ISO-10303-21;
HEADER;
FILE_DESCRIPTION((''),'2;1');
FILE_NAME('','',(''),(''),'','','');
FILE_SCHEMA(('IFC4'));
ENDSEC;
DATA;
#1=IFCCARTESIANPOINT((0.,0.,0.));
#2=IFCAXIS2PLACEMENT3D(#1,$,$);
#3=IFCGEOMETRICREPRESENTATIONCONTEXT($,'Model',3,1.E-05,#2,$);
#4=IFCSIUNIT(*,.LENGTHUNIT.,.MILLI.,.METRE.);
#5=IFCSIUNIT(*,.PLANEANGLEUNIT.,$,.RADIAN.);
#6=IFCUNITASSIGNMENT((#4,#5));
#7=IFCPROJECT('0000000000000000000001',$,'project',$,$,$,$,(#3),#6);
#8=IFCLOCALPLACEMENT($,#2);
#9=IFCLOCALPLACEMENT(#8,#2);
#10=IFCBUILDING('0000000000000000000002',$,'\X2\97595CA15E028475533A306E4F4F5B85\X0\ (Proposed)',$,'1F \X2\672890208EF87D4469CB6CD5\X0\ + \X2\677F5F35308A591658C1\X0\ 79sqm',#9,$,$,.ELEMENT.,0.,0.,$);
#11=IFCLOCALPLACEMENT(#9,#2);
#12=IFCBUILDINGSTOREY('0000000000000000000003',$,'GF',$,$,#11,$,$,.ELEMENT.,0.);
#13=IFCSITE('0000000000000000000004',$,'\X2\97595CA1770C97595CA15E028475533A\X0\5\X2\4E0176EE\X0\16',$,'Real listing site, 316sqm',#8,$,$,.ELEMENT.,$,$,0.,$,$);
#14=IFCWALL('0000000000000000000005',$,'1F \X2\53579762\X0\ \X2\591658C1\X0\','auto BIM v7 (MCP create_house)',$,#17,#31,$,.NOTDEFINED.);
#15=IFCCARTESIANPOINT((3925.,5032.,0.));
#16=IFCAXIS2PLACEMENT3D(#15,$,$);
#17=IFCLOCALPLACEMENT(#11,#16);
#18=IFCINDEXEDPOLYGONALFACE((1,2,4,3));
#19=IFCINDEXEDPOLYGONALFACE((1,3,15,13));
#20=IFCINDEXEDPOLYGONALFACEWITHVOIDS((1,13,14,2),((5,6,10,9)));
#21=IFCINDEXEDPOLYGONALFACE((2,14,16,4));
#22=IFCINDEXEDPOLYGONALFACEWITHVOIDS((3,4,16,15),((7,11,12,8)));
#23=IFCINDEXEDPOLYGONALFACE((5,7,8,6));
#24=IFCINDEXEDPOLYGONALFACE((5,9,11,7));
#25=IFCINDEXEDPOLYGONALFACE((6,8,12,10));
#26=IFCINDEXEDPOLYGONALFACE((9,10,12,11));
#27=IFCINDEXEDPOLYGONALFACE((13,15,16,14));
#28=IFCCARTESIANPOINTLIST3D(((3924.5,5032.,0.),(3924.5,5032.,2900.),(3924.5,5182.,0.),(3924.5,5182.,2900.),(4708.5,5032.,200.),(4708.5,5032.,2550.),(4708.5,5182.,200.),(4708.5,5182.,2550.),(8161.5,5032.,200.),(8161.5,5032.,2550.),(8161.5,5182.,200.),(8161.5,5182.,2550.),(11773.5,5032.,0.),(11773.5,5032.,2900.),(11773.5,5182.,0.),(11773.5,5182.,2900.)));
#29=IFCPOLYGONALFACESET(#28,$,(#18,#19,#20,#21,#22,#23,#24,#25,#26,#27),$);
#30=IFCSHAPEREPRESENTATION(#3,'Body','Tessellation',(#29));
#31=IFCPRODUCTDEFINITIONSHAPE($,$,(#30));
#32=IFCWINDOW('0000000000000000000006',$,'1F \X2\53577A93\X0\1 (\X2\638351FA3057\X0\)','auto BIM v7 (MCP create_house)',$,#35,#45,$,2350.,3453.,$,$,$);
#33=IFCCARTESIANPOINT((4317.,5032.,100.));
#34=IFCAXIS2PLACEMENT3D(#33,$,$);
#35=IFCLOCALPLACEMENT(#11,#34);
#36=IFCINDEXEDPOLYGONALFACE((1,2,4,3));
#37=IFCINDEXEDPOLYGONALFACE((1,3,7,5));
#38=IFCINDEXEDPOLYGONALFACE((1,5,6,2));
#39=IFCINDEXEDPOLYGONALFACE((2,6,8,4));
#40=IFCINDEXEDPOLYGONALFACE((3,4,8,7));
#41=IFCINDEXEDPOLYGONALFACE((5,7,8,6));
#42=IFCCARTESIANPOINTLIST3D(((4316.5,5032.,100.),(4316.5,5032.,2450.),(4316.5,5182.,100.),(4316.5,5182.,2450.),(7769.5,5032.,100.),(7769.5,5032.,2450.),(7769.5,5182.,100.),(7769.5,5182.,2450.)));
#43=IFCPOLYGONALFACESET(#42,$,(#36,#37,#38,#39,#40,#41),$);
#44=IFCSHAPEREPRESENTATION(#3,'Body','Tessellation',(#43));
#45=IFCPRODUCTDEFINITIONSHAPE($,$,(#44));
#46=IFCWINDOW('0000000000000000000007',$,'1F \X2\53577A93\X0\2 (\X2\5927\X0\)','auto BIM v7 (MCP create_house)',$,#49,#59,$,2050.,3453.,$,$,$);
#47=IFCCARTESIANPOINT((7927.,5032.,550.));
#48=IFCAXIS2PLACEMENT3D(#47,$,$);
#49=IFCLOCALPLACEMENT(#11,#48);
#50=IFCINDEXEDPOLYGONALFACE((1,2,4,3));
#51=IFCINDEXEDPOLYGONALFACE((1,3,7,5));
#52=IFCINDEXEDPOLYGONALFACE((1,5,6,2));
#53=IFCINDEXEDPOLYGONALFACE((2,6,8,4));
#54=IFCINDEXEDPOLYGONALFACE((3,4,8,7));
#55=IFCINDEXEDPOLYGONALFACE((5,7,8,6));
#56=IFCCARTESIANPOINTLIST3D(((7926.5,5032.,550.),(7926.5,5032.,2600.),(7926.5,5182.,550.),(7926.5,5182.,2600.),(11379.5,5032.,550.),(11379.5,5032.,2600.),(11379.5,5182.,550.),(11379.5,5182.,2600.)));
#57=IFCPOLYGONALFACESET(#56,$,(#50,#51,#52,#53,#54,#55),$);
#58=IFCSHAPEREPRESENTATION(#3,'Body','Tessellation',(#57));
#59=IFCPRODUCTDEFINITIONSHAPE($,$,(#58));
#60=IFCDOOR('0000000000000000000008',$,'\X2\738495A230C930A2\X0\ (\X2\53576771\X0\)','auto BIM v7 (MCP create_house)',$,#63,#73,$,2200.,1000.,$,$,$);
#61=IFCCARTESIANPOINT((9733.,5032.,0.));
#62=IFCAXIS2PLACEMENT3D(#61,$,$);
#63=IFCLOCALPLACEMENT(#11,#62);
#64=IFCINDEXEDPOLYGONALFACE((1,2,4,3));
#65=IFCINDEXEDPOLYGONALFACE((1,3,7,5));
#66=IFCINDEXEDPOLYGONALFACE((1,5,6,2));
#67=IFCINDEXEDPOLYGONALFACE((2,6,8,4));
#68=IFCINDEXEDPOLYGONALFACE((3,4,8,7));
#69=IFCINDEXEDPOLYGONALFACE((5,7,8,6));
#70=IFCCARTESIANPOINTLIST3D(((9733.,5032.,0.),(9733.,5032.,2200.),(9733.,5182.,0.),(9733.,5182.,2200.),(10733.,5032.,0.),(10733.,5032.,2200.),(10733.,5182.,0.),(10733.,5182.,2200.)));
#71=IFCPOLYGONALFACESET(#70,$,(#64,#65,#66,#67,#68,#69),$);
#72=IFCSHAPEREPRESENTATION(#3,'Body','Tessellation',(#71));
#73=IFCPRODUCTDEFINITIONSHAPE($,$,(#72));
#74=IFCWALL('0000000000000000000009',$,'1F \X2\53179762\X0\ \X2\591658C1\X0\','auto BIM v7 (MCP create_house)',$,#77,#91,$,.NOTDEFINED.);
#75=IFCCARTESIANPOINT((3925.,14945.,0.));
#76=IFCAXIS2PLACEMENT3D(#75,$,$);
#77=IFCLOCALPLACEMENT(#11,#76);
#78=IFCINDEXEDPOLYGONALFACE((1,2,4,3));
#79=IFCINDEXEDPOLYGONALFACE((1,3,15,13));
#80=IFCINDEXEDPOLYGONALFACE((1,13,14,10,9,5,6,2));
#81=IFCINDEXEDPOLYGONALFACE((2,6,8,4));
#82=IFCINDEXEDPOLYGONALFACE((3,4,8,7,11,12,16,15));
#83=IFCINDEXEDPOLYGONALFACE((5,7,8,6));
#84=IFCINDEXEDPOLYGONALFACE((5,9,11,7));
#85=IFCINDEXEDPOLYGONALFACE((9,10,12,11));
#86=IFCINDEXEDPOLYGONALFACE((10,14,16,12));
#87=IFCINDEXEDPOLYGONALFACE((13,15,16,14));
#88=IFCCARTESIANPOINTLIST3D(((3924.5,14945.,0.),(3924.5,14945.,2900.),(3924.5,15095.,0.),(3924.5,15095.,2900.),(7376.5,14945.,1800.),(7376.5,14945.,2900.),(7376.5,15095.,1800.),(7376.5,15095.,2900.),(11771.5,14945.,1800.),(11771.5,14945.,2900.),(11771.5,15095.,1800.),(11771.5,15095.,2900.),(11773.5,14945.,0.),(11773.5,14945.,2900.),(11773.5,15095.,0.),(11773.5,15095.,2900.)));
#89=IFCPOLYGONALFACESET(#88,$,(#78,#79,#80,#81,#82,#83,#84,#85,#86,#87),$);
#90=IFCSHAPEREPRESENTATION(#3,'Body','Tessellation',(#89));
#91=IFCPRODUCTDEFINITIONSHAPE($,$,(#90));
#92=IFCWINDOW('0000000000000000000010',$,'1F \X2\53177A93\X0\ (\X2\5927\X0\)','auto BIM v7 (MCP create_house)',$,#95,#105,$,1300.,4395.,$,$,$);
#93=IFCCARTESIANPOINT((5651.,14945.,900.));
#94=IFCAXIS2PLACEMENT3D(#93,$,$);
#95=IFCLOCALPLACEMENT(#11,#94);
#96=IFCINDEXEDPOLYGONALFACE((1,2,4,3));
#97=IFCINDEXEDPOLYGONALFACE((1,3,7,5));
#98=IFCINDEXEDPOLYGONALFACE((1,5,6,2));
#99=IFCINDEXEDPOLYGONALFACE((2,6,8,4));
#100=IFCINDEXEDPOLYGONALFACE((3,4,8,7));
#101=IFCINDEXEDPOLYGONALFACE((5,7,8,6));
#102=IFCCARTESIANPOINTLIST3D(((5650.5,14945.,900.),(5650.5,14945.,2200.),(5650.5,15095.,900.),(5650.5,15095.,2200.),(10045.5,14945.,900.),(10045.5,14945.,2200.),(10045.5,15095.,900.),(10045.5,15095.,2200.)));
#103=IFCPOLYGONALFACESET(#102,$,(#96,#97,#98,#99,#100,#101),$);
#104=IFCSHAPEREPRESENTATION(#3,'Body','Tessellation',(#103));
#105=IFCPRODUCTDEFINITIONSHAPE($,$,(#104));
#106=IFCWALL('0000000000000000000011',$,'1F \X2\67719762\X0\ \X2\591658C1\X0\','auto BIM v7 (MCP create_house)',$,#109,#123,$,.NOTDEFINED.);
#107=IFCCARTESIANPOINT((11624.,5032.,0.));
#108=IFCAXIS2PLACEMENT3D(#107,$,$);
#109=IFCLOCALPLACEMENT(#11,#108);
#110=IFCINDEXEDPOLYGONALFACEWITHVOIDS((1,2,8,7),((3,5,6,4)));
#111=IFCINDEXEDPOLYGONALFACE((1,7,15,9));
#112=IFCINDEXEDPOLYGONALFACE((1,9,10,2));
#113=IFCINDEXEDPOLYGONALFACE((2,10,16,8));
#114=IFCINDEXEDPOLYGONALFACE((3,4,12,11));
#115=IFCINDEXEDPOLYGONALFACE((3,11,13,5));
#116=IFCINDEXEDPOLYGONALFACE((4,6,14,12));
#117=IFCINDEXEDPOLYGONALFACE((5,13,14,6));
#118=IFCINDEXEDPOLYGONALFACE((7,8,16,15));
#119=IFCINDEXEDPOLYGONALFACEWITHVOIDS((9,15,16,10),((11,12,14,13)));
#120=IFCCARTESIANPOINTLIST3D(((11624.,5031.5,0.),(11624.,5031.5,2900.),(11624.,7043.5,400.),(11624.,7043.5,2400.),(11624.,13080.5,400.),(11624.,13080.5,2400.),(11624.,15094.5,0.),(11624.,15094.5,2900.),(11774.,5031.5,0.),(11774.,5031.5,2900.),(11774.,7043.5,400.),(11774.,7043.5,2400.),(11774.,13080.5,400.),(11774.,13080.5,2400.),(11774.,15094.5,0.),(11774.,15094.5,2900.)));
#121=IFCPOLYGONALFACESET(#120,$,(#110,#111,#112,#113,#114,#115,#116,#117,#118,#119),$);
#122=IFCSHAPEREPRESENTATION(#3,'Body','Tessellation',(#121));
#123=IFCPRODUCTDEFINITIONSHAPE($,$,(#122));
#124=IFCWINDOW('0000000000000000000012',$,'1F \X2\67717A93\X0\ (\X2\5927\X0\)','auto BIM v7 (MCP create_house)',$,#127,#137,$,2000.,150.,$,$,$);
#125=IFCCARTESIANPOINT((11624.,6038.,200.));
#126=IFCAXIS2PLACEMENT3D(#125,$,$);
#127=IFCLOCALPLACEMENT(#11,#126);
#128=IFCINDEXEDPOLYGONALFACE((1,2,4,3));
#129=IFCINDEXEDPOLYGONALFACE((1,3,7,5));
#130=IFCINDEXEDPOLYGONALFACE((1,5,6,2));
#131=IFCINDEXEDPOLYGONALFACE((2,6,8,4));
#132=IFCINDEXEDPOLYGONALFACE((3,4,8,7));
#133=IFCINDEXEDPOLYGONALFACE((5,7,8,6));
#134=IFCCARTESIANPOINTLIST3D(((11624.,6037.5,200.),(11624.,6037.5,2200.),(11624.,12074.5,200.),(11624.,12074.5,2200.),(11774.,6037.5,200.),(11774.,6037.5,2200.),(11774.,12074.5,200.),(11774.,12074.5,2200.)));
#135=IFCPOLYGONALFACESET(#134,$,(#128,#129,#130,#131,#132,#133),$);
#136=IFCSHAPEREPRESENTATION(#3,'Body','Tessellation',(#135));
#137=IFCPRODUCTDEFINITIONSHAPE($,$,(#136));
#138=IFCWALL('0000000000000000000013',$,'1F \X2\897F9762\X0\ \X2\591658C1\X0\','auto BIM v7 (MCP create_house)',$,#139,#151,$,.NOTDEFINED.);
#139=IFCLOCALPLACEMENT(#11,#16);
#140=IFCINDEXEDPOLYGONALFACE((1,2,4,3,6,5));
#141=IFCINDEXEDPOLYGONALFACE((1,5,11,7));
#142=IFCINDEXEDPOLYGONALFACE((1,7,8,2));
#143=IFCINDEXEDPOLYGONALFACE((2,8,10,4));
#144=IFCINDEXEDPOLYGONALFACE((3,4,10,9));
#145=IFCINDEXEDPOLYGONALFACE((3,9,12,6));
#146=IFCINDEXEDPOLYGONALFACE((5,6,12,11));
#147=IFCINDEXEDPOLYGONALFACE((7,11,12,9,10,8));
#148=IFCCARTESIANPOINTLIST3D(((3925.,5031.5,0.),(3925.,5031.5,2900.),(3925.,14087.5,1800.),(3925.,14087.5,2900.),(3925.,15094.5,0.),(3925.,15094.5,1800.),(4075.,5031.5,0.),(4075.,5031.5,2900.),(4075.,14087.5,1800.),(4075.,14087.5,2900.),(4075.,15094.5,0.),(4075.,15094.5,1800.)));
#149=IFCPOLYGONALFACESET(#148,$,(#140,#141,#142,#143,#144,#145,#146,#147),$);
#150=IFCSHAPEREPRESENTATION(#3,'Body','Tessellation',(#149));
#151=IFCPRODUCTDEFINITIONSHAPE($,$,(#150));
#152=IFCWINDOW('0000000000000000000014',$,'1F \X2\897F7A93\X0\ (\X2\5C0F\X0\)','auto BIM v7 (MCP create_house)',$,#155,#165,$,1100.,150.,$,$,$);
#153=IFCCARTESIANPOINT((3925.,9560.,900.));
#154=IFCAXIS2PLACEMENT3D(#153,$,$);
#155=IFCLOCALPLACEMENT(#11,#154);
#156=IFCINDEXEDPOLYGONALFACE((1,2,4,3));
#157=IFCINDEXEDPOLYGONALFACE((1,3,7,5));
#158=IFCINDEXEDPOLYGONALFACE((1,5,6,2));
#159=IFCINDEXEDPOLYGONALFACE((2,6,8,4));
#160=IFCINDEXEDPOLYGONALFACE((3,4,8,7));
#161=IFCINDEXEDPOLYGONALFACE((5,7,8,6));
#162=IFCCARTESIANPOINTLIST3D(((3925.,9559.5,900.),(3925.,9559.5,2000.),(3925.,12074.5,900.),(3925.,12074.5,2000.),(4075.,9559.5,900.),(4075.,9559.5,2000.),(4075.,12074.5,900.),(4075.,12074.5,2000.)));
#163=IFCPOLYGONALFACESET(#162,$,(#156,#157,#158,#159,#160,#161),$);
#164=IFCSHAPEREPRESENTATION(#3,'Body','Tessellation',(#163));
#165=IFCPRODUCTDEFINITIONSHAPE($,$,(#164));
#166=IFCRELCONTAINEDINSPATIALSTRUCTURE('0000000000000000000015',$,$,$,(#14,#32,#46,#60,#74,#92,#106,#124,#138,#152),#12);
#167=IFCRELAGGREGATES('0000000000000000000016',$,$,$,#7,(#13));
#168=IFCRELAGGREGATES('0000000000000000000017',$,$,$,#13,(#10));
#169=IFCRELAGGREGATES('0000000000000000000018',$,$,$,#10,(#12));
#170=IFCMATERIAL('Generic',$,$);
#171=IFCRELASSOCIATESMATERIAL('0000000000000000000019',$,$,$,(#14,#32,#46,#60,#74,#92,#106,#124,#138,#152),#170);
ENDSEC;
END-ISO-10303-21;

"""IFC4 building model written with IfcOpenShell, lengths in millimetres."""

from ifc_helpers import new_model, si_unit, frame, frame_2d, origin, place, context, project, spatial, rectangle, extrude, material, element, fill, save


model = new_model("IFC4")

# Units and contexts
model_context = context("Model", 3, precision=1e-05, world=origin())
ifc_project = project(units=[si_unit("LENGTHUNIT", "METRE", prefix="MILLI"), si_unit("PLANEANGLEUNIT", "RADIAN")], contexts=[model_context])

# Site, building, storey
site_placement = place(None, origin())
site = spatial("IfcSite", under=ifc_project, at=site_placement, Name="静岡県静岡市葵区5丁目16", ObjectType="Real listing site, 316sqm", CompositionType="ELEMENT", RefElevation=0.0)
building_placement = place(site_placement, origin())
building = spatial("IfcBuilding", under=site, at=building_placement, Name="静岡市葵区の住宅 (Proposed)", ObjectType="1F 木造軸組構法 + 板張り外壁 79sqm", CompositionType="ELEMENT", ElevationOfRefHeight=0.0, ElevationOfTerrain=0.0)
storey_placement = place(building_placement, origin())
storey = spatial("IfcBuildingStorey", under=building, at=storey_placement, Name="GF", CompositionType="ELEMENT", Elevation=0.0)

# Shared definitions
ifc_material = material(Name="Generic")

# Wall, openings, windows, door
wall_1_placement = place(storey_placement, frame((3925.0, 5032.0, 0.0)))
wall_1 = element("IfcWall", 1, at=wall_1_placement, inside=storey, material=ifc_material, Name="1F 南面 外壁", Description="auto BIM v7 (MCP create_house)", PredefinedType="NOTDEFINED", context=model_context, shape_type="SweptSolid", body=[
    extrude(rectangle(XDim=7849.0, YDim=150.0, at=frame_2d((3924.0, 75.0))), frame((3925.0, 5032.0, 0.0)), (0.0, 0.0, 1.0), 2900.0),
])
opening_1_placement = place(storey_placement, frame((4317.0, 5032.0, 100.0)))
opening_1 = element("IfcOpeningElement", 2, at=opening_1_placement, cuts=wall_1, PredefinedType="NOTDEFINED", context=model_context, shape_type="SweptSolid", body=[
    extrude(rectangle(XDim=3453.0, YDim=150.0, at=frame_2d((1726.0, 75.0))), frame((4317.0, 5032.0, 100.0)), (0.0, 0.0, 1.0), 2350.0),
])
opening_2_placement = place(storey_placement, frame((7927.0, 5032.0, 550.0)))
opening_2 = element("IfcOpeningElement", 3, at=opening_2_placement, cuts=wall_1, PredefinedType="NOTDEFINED", context=model_context, shape_type="SweptSolid", body=[
    extrude(rectangle(XDim=3453.0, YDim=150.0, at=frame_2d((1726.0, 75.0))), frame((7927.0, 5032.0, 550.0)), (0.0, 0.0, 1.0), 2050.0),
])
opening_3_placement = place(storey_placement, frame((9733.0, 5032.0, 0.0)))
opening_3 = element("IfcOpeningElement", 4, at=opening_3_placement, cuts=wall_1, PredefinedType="NOTDEFINED", context=model_context, shape_type="SweptSolid", body=[
    extrude(rectangle(XDim=1000.0, YDim=150.0, at=frame_2d((500.0, 75.0))), frame((9733.0, 5032.0, 0.0)), (0.0, 0.0, 1.0), 2200.0),
])
window_1_placement = place(storey_placement, frame((4317.0, 5032.0, 100.0)))
window_1 = element("IfcWindow", 5, at=window_1_placement, inside=storey, material=ifc_material, Name="1F 南窓1 (掃出し)", Description="auto BIM v7 (MCP create_house)", OverallHeight=2350.0, OverallWidth=3453.0, context=model_context, shape_type="SweptSolid", body=[
    extrude(rectangle(XDim=3453.0, YDim=150.0, at=frame_2d((1726.0, 75.0))), frame((4317.0, 5032.0, 100.0)), (0.0, 0.0, 1.0), 2350.0),
])
fill(opening_1, window_1)
window_2_placement = place(storey_placement, frame((7927.0, 5032.0, 550.0)))
window_2 = element("IfcWindow", 6, at=window_2_placement, inside=storey, material=ifc_material, Name="1F 南窓2 (大)", Description="auto BIM v7 (MCP create_house)", OverallHeight=2050.0, OverallWidth=3453.0, context=model_context, shape_type="SweptSolid", body=[
    extrude(rectangle(XDim=3453.0, YDim=150.0, at=frame_2d((1726.0, 75.0))), frame((7927.0, 5032.0, 550.0)), (0.0, 0.0, 1.0), 2050.0),
])
fill(opening_2, window_2)
door_placement = place(storey_placement, frame((9733.0, 5032.0, 0.0)))
door = element("IfcDoor", 7, at=door_placement, inside=storey, material=ifc_material, Name="玄関ドア (南東)", Description="auto BIM v7 (MCP create_house)", OverallHeight=2200.0, OverallWidth=1000.0, context=model_context, shape_type="SweptSolid", body=[
    extrude(rectangle(XDim=1000.0, YDim=150.0, at=frame_2d((500.0, 75.0))), frame((9733.0, 5032.0, 0.0)), (0.0, 0.0, 1.0), 2200.0),
])
fill(opening_3, door)

# Walls, openings, windows
wall_2_placement = place(storey_placement, frame((3925.0, 14945.0, 0.0)))
wall_2 = element("IfcWall", 8, at=wall_2_placement, inside=storey, material=ifc_material, Name="1F 北面 外壁", Description="auto BIM v7 (MCP create_house)", PredefinedType="NOTDEFINED", context=model_context, shape_type="SweptSolid", body=[
    extrude(rectangle(XDim=7849.0, YDim=150.0, at=frame_2d((3924.0, 75.0))), frame((3925.0, 14945.0, 0.0)), (0.0, 0.0, 1.0), 2900.0),
])
opening_4_placement = place(storey_placement, frame((5651.0, 14945.0, 900.0)))
opening_4 = element("IfcOpeningElement", 9, at=opening_4_placement, cuts=wall_2, PredefinedType="NOTDEFINED", context=model_context, shape_type="SweptSolid", body=[
    extrude(rectangle(XDim=4395.0, YDim=150.0, at=frame_2d((2197.0, 75.0))), frame((5651.0, 14945.0, 900.0)), (0.0, 0.0, 1.0), 1300.0),
])
window_3_placement = place(storey_placement, frame((5651.0, 14945.0, 900.0)))
window_3 = element("IfcWindow", 10, at=window_3_placement, inside=storey, material=ifc_material, Name="1F 北窓 (大)", Description="auto BIM v7 (MCP create_house)", OverallHeight=1300.0, OverallWidth=4395.0, context=model_context, shape_type="SweptSolid", body=[
    extrude(rectangle(XDim=4395.0, YDim=150.0, at=frame_2d((2197.0, 75.0))), frame((5651.0, 14945.0, 900.0)), (0.0, 0.0, 1.0), 1300.0),
])
fill(opening_4, window_3)
wall_3_placement = place(storey_placement, frame((11624.0, 5032.0, 0.0)))
wall_3 = element("IfcWall", 11, at=wall_3_placement, inside=storey, material=ifc_material, Name="1F 東面 外壁", Description="auto BIM v7 (MCP create_house)", PredefinedType="NOTDEFINED", context=model_context, shape_type="SweptSolid", body=[
    extrude(rectangle(XDim=150.0, YDim=10063.0, at=frame_2d((75.0, 5031.0))), frame((11624.0, 5032.0, 0.0)), (0.0, 0.0, 1.0), 2900.0),
])
opening_5_placement = place(storey_placement, frame((11624.0, 6038.0, 200.0)))
opening_5 = element("IfcOpeningElement", 12, at=opening_5_placement, cuts=wall_3, PredefinedType="NOTDEFINED", context=model_context, shape_type="SweptSolid", body=[
    extrude(rectangle(XDim=150.0, YDim=6037.0, at=frame_2d((75.0, 3018.0))), frame((11624.0, 6038.0, 200.0)), (0.0, 0.0, 1.0), 2000.0),
])
window_4_placement = place(storey_placement, frame((11624.0, 6038.0, 200.0)))
window_4 = element("IfcWindow", 13, at=window_4_placement, inside=storey, material=ifc_material, Name="1F 東窓 (大)", Description="auto BIM v7 (MCP create_house)", OverallHeight=2000.0, OverallWidth=150.0, context=model_context, shape_type="SweptSolid", body=[
    extrude(rectangle(XDim=150.0, YDim=6037.0, at=frame_2d((75.0, 3018.0))), frame((11624.0, 6038.0, 200.0)), (0.0, 0.0, 1.0), 2000.0),
])
fill(opening_5, window_4)
wall_4_placement = place(storey_placement, frame((3925.0, 5032.0, 0.0)))
wall_4 = element("IfcWall", 14, at=wall_4_placement, inside=storey, material=ifc_material, Name="1F 西面 外壁", Description="auto BIM v7 (MCP create_house)", PredefinedType="NOTDEFINED", context=model_context, shape_type="SweptSolid", body=[
    extrude(rectangle(XDim=150.0, YDim=10063.0, at=frame_2d((75.0, 5031.0))), frame((3925.0, 5032.0, 0.0)), (0.0, 0.0, 1.0), 2900.0),
])
opening_6_placement = place(storey_placement, frame((3925.0, 9560.0, 900.0)))
opening_6 = element("IfcOpeningElement", 15, at=opening_6_placement, cuts=wall_4, PredefinedType="NOTDEFINED", context=model_context, shape_type="SweptSolid", body=[
    extrude(rectangle(XDim=150.0, YDim=2515.0, at=frame_2d((75.0, 1257.0))), frame((3925.0, 9560.0, 900.0)), (0.0, 0.0, 1.0), 1100.0),
])
window_5_placement = place(storey_placement, frame((3925.0, 9560.0, 900.0)))
window_5 = element("IfcWindow", 16, at=window_5_placement, inside=storey, material=ifc_material, Name="1F 西窓 (小)", Description="auto BIM v7 (MCP create_house)", OverallHeight=1100.0, OverallWidth=150.0, context=model_context, shape_type="SweptSolid", body=[
    extrude(rectangle(XDim=150.0, YDim=2515.0, at=frame_2d((75.0, 1257.0))), frame((3925.0, 9560.0, 900.0)), (0.0, 0.0, 1.0), 1100.0),
])
fill(opening_6, window_5)

save(model, "model.ifc")
